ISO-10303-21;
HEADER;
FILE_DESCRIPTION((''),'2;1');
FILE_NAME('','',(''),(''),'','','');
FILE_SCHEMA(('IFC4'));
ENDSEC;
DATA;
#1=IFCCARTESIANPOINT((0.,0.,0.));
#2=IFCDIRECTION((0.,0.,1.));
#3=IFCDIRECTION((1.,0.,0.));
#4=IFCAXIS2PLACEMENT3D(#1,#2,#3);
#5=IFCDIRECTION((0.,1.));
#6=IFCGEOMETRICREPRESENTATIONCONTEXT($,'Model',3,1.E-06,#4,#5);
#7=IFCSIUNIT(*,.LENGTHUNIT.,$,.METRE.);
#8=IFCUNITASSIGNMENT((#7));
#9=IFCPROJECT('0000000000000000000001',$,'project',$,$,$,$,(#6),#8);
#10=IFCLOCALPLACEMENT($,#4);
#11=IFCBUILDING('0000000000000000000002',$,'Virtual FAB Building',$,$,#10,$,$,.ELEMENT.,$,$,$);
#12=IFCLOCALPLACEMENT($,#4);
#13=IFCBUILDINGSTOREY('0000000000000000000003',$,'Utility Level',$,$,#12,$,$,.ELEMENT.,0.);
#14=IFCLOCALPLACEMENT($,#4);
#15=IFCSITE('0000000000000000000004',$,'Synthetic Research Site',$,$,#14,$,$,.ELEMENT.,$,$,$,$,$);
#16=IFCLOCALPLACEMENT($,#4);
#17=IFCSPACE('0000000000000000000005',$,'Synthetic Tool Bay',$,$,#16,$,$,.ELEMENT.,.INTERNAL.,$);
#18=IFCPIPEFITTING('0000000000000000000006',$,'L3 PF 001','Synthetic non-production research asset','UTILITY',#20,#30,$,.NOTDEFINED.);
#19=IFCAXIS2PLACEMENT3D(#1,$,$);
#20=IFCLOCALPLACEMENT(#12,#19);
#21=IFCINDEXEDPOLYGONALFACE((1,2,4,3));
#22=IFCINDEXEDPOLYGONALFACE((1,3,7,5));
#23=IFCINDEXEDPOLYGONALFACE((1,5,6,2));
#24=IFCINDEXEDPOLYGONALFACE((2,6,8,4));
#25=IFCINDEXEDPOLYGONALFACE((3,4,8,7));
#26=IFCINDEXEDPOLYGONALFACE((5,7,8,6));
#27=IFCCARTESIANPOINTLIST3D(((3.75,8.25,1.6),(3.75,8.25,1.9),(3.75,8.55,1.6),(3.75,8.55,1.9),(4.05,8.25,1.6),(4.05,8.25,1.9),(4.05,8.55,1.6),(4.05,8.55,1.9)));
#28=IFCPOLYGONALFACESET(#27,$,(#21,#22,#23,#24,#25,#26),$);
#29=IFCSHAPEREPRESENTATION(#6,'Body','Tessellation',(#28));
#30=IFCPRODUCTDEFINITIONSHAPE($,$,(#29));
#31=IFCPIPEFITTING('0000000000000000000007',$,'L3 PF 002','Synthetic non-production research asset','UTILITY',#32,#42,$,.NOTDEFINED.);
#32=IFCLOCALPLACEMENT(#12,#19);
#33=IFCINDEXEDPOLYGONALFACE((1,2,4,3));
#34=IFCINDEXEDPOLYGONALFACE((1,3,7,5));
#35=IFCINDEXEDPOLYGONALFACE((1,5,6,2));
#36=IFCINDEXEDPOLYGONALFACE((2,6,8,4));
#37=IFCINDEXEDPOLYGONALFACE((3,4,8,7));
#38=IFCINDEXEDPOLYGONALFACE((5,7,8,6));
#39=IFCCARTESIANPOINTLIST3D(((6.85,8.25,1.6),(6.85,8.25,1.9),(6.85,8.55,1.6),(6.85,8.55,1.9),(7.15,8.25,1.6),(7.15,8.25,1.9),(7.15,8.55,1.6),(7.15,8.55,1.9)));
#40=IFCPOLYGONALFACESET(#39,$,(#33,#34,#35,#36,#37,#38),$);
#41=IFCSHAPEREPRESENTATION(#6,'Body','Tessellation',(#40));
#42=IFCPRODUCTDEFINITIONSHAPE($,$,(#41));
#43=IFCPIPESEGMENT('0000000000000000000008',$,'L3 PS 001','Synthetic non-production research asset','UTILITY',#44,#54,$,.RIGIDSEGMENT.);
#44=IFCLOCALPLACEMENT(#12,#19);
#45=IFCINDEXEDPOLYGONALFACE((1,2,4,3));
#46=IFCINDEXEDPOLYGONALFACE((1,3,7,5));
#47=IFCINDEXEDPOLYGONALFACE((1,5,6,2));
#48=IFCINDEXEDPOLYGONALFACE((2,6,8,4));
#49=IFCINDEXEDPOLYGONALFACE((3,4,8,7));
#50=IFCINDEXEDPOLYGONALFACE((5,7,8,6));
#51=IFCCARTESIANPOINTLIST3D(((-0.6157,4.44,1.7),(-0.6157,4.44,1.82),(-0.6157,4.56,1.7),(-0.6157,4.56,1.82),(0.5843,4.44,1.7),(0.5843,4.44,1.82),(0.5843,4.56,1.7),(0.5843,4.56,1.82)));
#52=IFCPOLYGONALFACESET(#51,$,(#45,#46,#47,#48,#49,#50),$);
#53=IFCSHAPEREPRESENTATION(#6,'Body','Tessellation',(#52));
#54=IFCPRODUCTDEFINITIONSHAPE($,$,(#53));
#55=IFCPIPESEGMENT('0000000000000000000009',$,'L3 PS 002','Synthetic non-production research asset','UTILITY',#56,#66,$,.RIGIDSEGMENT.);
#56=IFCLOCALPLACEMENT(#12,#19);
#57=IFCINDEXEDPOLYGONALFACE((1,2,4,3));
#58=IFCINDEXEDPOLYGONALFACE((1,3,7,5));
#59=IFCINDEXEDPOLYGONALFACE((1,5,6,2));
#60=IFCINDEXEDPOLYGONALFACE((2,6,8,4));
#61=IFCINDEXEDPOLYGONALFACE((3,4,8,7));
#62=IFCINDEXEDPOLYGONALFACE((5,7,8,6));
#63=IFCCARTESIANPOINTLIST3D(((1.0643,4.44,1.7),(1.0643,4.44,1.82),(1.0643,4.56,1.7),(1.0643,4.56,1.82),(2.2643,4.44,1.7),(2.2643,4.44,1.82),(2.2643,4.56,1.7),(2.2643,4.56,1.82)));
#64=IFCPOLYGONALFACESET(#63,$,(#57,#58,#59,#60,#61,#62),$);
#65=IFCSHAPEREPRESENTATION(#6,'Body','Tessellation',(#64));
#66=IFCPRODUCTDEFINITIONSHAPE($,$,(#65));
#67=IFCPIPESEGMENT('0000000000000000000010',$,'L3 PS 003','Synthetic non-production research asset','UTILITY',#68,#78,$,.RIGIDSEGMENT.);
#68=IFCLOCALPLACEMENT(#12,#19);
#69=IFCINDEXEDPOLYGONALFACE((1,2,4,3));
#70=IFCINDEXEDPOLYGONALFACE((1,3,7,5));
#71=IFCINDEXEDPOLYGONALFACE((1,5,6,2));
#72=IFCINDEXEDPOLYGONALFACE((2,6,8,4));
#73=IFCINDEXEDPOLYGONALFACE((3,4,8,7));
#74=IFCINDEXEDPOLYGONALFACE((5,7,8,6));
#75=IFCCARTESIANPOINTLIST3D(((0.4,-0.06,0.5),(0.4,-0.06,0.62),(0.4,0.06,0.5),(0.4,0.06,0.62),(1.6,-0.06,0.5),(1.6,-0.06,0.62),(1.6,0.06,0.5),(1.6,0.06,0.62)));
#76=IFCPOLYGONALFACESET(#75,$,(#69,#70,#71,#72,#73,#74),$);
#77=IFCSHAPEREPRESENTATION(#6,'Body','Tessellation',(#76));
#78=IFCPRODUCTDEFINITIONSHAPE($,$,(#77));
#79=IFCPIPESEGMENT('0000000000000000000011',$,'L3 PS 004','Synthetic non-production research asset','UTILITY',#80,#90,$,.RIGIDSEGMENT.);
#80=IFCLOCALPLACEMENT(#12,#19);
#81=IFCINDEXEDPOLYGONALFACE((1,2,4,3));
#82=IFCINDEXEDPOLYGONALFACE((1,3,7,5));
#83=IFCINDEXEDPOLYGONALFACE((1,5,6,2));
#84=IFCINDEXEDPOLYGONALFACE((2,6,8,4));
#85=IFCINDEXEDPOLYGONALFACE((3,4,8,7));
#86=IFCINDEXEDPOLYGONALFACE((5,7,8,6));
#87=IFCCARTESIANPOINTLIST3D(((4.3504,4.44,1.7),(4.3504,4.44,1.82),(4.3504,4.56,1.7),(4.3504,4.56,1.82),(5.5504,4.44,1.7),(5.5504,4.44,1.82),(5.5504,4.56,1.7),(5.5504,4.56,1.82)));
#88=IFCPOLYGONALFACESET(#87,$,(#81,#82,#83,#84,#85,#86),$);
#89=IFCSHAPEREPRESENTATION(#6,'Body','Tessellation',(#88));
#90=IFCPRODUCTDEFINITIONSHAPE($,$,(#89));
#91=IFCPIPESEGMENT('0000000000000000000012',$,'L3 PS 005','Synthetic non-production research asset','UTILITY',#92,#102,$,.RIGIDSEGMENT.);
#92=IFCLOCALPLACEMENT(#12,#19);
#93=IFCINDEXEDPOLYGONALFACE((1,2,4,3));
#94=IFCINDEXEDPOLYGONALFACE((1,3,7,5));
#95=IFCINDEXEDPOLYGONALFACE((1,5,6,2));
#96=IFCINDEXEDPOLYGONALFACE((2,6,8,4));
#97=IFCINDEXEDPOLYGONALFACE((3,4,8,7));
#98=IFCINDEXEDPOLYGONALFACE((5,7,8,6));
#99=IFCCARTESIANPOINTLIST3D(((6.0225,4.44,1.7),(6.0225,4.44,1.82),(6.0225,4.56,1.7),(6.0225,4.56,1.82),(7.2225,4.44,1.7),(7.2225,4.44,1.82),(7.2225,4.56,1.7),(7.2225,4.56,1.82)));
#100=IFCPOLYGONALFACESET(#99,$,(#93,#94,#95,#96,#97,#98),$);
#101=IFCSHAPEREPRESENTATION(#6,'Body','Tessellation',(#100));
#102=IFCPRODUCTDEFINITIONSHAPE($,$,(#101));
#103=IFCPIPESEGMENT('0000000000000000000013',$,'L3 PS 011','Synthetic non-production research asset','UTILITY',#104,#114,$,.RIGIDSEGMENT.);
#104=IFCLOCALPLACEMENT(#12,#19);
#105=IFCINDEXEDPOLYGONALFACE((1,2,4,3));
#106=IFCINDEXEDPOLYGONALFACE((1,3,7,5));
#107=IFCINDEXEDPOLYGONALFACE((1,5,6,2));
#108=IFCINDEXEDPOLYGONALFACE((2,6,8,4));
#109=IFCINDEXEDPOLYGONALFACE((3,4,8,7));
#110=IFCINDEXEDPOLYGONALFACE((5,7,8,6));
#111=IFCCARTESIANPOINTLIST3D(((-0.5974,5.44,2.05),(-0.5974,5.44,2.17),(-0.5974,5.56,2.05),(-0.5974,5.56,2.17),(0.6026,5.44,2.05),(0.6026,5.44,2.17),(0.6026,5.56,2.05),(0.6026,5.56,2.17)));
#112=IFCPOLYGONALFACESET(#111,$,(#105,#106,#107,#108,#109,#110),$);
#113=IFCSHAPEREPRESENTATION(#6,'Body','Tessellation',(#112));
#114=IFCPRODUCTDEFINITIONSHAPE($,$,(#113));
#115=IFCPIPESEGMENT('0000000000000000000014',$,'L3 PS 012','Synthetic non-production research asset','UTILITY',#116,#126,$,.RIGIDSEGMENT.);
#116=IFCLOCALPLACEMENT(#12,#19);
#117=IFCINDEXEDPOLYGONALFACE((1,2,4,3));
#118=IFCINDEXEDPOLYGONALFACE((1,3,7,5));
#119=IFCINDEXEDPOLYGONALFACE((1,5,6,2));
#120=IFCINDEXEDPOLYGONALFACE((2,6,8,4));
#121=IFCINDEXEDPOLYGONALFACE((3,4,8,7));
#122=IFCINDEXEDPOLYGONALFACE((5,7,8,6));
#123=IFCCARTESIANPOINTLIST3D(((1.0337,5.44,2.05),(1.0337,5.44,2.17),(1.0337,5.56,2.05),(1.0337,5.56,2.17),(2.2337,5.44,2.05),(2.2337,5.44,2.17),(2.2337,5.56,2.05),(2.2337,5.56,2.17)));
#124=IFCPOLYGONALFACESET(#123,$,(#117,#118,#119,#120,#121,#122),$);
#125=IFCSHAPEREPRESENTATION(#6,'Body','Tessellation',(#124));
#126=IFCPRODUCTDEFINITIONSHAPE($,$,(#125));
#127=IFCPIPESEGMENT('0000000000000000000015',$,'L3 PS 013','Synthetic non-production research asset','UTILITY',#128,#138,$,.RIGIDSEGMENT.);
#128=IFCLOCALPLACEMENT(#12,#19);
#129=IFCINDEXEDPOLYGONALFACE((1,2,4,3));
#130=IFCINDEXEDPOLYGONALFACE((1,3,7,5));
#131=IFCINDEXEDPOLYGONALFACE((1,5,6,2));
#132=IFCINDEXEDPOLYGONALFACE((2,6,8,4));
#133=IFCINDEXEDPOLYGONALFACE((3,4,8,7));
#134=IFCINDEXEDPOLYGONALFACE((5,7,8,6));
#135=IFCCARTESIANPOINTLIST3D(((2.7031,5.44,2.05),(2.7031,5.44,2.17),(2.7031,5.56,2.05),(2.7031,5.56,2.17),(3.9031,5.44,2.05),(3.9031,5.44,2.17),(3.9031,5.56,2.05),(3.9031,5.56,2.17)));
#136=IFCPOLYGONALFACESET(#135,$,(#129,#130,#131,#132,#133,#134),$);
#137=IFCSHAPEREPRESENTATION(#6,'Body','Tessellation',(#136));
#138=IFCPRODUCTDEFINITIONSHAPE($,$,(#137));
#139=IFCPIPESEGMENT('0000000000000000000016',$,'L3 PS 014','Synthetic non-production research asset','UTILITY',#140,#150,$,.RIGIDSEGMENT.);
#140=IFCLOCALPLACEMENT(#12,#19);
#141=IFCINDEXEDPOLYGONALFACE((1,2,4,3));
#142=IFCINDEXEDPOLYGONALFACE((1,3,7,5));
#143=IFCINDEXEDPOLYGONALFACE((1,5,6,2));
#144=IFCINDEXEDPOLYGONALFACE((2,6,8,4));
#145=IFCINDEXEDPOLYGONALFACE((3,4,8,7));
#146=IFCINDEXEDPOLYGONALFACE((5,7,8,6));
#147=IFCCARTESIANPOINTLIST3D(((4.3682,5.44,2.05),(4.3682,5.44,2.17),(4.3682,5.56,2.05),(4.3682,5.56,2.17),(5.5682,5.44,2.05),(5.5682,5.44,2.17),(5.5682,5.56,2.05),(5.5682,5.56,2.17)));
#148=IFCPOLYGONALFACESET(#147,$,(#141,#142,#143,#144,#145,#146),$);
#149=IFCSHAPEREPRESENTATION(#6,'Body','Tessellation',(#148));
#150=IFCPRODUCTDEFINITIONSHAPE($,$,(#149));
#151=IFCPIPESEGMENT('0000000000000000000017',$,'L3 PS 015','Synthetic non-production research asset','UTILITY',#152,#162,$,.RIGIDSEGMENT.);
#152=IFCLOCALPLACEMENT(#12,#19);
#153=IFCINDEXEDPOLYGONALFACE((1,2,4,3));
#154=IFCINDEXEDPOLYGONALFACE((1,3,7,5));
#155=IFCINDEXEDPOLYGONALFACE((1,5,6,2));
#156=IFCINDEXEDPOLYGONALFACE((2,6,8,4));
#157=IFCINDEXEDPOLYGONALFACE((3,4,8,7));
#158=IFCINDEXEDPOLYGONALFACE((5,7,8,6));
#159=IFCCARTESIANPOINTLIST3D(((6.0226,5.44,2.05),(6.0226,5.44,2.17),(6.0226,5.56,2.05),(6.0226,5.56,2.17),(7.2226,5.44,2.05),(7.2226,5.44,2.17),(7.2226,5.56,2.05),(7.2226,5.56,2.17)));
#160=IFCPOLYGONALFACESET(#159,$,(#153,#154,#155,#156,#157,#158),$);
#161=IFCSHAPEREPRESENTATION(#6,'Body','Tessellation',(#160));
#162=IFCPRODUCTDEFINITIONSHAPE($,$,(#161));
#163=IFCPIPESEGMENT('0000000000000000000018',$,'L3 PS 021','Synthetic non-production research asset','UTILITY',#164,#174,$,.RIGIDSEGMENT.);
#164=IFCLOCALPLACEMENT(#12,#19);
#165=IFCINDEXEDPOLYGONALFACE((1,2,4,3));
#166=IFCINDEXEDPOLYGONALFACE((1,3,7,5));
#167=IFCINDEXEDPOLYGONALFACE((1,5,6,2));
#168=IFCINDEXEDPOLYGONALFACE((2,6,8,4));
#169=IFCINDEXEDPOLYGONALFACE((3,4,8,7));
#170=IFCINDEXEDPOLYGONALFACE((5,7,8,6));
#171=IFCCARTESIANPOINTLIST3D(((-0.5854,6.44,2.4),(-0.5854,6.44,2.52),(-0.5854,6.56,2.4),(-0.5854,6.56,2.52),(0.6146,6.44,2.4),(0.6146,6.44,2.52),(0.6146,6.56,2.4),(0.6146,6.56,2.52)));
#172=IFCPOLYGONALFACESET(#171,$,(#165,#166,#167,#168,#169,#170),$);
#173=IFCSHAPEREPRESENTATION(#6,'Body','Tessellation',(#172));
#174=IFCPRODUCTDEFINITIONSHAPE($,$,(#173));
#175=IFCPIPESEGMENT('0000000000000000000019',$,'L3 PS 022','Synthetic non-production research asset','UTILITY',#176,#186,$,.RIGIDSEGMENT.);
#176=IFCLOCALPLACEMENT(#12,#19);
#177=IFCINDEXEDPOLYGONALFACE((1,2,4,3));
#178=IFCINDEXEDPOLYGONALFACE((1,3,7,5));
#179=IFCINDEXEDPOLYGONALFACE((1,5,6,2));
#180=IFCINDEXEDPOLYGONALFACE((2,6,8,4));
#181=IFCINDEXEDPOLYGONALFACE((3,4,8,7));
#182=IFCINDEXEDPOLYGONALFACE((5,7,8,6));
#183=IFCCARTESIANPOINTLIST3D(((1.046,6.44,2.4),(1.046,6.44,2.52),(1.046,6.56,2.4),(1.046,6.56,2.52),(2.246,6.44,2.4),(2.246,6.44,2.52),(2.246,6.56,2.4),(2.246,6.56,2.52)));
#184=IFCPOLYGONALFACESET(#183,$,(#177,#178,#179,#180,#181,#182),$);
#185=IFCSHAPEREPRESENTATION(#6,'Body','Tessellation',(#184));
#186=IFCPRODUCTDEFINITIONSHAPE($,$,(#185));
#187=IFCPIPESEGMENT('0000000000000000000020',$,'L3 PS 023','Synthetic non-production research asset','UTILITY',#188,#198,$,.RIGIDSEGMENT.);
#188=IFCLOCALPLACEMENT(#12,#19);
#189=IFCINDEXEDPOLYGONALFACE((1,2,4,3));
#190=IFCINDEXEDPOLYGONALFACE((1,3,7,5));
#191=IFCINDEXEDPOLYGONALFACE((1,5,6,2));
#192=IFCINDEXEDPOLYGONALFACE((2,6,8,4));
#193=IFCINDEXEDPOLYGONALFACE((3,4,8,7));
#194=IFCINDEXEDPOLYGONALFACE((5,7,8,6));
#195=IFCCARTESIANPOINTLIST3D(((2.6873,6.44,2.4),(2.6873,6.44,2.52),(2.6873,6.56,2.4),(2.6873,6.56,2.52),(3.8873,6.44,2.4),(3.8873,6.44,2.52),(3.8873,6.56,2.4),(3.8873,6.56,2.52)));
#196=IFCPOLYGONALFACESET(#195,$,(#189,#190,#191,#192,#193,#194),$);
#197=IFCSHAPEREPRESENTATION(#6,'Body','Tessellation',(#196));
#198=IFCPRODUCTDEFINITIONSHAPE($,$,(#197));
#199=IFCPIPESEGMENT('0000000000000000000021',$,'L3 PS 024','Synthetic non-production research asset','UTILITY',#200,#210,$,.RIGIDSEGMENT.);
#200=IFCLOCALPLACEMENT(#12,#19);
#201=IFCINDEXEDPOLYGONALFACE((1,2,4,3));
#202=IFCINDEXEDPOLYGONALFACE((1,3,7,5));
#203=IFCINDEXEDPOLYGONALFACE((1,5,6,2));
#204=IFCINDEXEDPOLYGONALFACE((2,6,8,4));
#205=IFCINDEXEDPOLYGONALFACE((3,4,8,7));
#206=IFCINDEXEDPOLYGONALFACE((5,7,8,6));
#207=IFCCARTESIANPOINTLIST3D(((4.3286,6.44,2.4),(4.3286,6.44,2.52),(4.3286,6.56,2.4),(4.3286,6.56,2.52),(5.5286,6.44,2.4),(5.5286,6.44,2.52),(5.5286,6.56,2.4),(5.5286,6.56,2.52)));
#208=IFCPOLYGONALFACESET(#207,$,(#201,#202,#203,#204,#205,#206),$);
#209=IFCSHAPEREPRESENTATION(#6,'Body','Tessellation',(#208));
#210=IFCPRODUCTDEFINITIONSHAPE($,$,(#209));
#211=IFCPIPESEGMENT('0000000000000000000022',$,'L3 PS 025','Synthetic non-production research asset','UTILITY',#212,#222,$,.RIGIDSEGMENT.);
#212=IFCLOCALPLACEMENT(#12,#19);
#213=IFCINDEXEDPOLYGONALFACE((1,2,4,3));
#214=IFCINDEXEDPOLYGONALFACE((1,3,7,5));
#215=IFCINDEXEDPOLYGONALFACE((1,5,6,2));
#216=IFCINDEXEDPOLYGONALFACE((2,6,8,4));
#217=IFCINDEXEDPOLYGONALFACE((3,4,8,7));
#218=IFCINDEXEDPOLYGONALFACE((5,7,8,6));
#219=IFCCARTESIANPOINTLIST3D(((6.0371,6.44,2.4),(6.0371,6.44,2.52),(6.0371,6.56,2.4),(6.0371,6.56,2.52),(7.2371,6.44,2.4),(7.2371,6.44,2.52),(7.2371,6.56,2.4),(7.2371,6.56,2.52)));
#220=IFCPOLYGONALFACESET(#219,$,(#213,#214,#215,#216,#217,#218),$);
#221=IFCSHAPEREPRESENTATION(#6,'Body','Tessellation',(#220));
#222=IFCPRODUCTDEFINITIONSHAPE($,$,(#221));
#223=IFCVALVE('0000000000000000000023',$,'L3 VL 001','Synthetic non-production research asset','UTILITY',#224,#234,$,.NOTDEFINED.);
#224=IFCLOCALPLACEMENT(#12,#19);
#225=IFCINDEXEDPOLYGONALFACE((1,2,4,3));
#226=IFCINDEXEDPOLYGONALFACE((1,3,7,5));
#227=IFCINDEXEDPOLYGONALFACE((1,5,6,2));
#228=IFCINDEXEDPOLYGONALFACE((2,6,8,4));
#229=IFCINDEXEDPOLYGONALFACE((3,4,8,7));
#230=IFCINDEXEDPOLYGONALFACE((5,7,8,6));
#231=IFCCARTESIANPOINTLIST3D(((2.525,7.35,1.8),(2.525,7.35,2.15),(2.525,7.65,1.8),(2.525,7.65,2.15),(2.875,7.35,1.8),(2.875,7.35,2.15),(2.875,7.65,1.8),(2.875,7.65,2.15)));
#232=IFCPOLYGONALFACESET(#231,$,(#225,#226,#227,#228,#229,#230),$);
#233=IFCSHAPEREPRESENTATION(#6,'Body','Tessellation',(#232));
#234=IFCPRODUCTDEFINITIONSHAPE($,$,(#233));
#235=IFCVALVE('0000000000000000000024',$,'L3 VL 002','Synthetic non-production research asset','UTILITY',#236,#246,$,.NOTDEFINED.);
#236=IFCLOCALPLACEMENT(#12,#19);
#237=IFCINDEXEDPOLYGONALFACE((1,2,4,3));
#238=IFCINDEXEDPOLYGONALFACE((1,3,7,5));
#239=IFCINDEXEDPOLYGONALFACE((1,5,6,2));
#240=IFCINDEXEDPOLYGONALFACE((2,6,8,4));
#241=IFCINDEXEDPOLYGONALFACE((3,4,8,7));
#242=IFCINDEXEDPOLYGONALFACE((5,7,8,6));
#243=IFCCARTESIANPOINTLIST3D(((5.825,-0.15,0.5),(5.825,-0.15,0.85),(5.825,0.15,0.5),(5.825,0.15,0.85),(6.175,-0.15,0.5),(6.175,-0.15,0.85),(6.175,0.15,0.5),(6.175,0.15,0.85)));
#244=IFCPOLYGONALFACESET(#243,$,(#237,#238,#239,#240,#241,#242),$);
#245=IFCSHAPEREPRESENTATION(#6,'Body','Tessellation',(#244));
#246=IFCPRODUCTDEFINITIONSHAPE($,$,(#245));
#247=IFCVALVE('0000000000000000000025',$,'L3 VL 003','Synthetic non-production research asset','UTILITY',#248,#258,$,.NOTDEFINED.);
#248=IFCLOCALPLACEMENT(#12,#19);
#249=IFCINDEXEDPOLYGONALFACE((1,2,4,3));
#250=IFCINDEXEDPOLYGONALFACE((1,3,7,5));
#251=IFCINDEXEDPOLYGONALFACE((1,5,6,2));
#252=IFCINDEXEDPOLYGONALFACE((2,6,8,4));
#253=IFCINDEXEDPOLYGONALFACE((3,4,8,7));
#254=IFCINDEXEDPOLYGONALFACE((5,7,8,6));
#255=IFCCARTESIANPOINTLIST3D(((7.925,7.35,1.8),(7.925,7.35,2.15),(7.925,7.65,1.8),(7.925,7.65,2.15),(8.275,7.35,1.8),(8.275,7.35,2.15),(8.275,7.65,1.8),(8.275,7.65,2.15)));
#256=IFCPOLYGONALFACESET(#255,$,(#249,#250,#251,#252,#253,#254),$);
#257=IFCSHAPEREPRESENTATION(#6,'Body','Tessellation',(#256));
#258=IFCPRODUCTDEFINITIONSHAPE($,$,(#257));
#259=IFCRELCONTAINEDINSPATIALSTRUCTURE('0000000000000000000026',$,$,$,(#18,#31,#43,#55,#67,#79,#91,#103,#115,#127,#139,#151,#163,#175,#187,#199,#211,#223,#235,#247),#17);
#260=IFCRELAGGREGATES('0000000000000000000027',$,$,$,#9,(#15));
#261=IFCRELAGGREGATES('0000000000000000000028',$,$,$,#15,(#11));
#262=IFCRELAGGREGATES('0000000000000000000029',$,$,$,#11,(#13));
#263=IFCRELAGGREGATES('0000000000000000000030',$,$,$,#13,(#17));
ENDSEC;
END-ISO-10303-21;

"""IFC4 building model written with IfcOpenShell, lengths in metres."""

from ifc_helpers import new_model, si_unit, direction, frame, origin_with_axes, origin_2d_with_axis, place, context, project, spatial, rectangle, extrude, element, save


model = new_model("IFC4")

# Units and contexts
model_context = context("Model", 3, precision=1e-06, world=origin_with_axes(), true_north=direction((0.0, 1.0)))
ifc_project = project(units=[si_unit("LENGTHUNIT", "METRE")], contexts=[model_context])

# Site, building, storey, space
site_placement = place(None, origin_with_axes())
site = spatial("IfcSite", under=ifc_project, at=site_placement, Name="Synthetic Research Site", CompositionType="ELEMENT")
building_placement = place(None, origin_with_axes())
building = spatial("IfcBuilding", under=site, at=building_placement, Name="Virtual FAB Building", CompositionType="ELEMENT")
storey_placement = place(None, origin_with_axes())
storey = spatial("IfcBuildingStorey", under=building, at=storey_placement, Name="Utility Level", CompositionType="ELEMENT", Elevation=0.0)
space_placement = place(None, origin_with_axes())
space = spatial("IfcSpace", under=storey, at=space_placement, Name="Synthetic Tool Bay", CompositionType="ELEMENT", PredefinedType="INTERNAL")

# Pipe fittings
for number, where, z_axis, x_axis, name in (
    (1, (3.9, 8.4, 1.6), (0.0, 0.0, 1.0), (1.0, 0.0, 0.0), "L3 PF 001"),
    (2, (7.0, 8.4, 1.6), (0.0, 0.0, 1.0), (1.0, 0.0, 0.0), "L3 PF 002"),
):
    element("IfcPipeFitting", number, at=place(None, frame(where, z_axis=z_axis, x_axis=x_axis)), inside=space, Name=name, Description="Synthetic non-production research asset", ObjectType="UTILITY", PredefinedType="NOTDEFINED", context=model_context, shape_type="SweptSolid", body=[
        extrude(rectangle(XDim=0.3, YDim=0.3, at=origin_2d_with_axis()), origin_with_axes(), (0.0, 0.0, 1.0), 0.3),
    ])

# Pipe segments
for number, where, z_axis, x_axis, name in (
    (3, (-0.0157, 4.5, 1.7), (0.0, 0.0, 1.0), (1.0, 0.0, 0.0), "L3 PS 001"),
    (4, (1.6643, 4.5, 1.7), (0.0, 0.0, 1.0), (1.0, 0.0, 0.0), "L3 PS 002"),
    (5, (1.0, 0.0, 0.5), (0.0, 0.0, 1.0), (1.0, 0.0, 0.0), "L3 PS 003"),
    (6, (4.9504, 4.5, 1.7), (0.0, 0.0, 1.0), (1.0, 0.0, 0.0), "L3 PS 004"),
    (7, (6.6225, 4.5, 1.7), (0.0, 0.0, 1.0), (1.0, 0.0, 0.0), "L3 PS 005"),
    (8, (0.0026, 5.5, 2.05), (0.0, 0.0, 1.0), (1.0, 0.0, 0.0), "L3 PS 011"),
    (9, (1.6337, 5.5, 2.05), (0.0, 0.0, 1.0), (1.0, 0.0, 0.0), "L3 PS 012"),
    (10, (3.3031, 5.5, 2.05), (0.0, 0.0, 1.0), (1.0, 0.0, 0.0), "L3 PS 013"),
    (11, (4.9682, 5.5, 2.05), (0.0, 0.0, 1.0), (1.0, 0.0, 0.0), "L3 PS 014"),
    (12, (6.6226, 5.5, 2.05), (0.0, 0.0, 1.0), (1.0, 0.0, 0.0), "L3 PS 015"),
    (13, (0.0146, 6.5, 2.4), (0.0, 0.0, 1.0), (1.0, 0.0, 0.0), "L3 PS 021"),
    (14, (1.646, 6.5, 2.4), (0.0, 0.0, 1.0), (1.0, 0.0, 0.0), "L3 PS 022"),
    (15, (3.2873, 6.5, 2.4), (0.0, 0.0, 1.0), (1.0, 0.0, 0.0), "L3 PS 023"),
    (16, (4.9286, 6.5, 2.4), (0.0, 0.0, 1.0), (1.0, 0.0, 0.0), "L3 PS 024"),
    (17, (6.6371, 6.5, 2.4), (0.0, 0.0, 1.0), (1.0, 0.0, 0.0), "L3 PS 025"),
):
    element("IfcPipeSegment", number, at=place(None, frame(where, z_axis=z_axis, x_axis=x_axis)), inside=space, Name=name, Description="Synthetic non-production research asset", ObjectType="UTILITY", PredefinedType="RIGIDSEGMENT", context=model_context, shape_type="SweptSolid", body=[
        extrude(rectangle(XDim=1.2, YDim=0.12, at=origin_2d_with_axis()), origin_with_axes(), (0.0, 0.0, 1.0), 0.12),
    ])

# Valves
for number, where, z_axis, x_axis, name in (
    (18, (2.7, 7.5, 1.8), (0.0, 0.0, 1.0), (1.0, 0.0, 0.0), "L3 VL 001"),
    (19, (6.0, 0.0, 0.5), (0.0, 0.0, 1.0), (1.0, 0.0, 0.0), "L3 VL 002"),
    (20, (8.1, 7.5, 1.8), (0.0, 0.0, 1.0), (1.0, 0.0, 0.0), "L3 VL 003"),
):
    element("IfcValve", number, at=place(None, frame(where, z_axis=z_axis, x_axis=x_axis)), inside=space, Name=name, Description="Synthetic non-production research asset", ObjectType="UTILITY", PredefinedType="NOTDEFINED", context=model_context, shape_type="SweptSolid", body=[
        extrude(rectangle(XDim=0.35, YDim=0.3, at=origin_2d_with_axis()), origin_with_axes(), (0.0, 0.0, 1.0), 0.35),
    ])

save(model, "model.ifc")
